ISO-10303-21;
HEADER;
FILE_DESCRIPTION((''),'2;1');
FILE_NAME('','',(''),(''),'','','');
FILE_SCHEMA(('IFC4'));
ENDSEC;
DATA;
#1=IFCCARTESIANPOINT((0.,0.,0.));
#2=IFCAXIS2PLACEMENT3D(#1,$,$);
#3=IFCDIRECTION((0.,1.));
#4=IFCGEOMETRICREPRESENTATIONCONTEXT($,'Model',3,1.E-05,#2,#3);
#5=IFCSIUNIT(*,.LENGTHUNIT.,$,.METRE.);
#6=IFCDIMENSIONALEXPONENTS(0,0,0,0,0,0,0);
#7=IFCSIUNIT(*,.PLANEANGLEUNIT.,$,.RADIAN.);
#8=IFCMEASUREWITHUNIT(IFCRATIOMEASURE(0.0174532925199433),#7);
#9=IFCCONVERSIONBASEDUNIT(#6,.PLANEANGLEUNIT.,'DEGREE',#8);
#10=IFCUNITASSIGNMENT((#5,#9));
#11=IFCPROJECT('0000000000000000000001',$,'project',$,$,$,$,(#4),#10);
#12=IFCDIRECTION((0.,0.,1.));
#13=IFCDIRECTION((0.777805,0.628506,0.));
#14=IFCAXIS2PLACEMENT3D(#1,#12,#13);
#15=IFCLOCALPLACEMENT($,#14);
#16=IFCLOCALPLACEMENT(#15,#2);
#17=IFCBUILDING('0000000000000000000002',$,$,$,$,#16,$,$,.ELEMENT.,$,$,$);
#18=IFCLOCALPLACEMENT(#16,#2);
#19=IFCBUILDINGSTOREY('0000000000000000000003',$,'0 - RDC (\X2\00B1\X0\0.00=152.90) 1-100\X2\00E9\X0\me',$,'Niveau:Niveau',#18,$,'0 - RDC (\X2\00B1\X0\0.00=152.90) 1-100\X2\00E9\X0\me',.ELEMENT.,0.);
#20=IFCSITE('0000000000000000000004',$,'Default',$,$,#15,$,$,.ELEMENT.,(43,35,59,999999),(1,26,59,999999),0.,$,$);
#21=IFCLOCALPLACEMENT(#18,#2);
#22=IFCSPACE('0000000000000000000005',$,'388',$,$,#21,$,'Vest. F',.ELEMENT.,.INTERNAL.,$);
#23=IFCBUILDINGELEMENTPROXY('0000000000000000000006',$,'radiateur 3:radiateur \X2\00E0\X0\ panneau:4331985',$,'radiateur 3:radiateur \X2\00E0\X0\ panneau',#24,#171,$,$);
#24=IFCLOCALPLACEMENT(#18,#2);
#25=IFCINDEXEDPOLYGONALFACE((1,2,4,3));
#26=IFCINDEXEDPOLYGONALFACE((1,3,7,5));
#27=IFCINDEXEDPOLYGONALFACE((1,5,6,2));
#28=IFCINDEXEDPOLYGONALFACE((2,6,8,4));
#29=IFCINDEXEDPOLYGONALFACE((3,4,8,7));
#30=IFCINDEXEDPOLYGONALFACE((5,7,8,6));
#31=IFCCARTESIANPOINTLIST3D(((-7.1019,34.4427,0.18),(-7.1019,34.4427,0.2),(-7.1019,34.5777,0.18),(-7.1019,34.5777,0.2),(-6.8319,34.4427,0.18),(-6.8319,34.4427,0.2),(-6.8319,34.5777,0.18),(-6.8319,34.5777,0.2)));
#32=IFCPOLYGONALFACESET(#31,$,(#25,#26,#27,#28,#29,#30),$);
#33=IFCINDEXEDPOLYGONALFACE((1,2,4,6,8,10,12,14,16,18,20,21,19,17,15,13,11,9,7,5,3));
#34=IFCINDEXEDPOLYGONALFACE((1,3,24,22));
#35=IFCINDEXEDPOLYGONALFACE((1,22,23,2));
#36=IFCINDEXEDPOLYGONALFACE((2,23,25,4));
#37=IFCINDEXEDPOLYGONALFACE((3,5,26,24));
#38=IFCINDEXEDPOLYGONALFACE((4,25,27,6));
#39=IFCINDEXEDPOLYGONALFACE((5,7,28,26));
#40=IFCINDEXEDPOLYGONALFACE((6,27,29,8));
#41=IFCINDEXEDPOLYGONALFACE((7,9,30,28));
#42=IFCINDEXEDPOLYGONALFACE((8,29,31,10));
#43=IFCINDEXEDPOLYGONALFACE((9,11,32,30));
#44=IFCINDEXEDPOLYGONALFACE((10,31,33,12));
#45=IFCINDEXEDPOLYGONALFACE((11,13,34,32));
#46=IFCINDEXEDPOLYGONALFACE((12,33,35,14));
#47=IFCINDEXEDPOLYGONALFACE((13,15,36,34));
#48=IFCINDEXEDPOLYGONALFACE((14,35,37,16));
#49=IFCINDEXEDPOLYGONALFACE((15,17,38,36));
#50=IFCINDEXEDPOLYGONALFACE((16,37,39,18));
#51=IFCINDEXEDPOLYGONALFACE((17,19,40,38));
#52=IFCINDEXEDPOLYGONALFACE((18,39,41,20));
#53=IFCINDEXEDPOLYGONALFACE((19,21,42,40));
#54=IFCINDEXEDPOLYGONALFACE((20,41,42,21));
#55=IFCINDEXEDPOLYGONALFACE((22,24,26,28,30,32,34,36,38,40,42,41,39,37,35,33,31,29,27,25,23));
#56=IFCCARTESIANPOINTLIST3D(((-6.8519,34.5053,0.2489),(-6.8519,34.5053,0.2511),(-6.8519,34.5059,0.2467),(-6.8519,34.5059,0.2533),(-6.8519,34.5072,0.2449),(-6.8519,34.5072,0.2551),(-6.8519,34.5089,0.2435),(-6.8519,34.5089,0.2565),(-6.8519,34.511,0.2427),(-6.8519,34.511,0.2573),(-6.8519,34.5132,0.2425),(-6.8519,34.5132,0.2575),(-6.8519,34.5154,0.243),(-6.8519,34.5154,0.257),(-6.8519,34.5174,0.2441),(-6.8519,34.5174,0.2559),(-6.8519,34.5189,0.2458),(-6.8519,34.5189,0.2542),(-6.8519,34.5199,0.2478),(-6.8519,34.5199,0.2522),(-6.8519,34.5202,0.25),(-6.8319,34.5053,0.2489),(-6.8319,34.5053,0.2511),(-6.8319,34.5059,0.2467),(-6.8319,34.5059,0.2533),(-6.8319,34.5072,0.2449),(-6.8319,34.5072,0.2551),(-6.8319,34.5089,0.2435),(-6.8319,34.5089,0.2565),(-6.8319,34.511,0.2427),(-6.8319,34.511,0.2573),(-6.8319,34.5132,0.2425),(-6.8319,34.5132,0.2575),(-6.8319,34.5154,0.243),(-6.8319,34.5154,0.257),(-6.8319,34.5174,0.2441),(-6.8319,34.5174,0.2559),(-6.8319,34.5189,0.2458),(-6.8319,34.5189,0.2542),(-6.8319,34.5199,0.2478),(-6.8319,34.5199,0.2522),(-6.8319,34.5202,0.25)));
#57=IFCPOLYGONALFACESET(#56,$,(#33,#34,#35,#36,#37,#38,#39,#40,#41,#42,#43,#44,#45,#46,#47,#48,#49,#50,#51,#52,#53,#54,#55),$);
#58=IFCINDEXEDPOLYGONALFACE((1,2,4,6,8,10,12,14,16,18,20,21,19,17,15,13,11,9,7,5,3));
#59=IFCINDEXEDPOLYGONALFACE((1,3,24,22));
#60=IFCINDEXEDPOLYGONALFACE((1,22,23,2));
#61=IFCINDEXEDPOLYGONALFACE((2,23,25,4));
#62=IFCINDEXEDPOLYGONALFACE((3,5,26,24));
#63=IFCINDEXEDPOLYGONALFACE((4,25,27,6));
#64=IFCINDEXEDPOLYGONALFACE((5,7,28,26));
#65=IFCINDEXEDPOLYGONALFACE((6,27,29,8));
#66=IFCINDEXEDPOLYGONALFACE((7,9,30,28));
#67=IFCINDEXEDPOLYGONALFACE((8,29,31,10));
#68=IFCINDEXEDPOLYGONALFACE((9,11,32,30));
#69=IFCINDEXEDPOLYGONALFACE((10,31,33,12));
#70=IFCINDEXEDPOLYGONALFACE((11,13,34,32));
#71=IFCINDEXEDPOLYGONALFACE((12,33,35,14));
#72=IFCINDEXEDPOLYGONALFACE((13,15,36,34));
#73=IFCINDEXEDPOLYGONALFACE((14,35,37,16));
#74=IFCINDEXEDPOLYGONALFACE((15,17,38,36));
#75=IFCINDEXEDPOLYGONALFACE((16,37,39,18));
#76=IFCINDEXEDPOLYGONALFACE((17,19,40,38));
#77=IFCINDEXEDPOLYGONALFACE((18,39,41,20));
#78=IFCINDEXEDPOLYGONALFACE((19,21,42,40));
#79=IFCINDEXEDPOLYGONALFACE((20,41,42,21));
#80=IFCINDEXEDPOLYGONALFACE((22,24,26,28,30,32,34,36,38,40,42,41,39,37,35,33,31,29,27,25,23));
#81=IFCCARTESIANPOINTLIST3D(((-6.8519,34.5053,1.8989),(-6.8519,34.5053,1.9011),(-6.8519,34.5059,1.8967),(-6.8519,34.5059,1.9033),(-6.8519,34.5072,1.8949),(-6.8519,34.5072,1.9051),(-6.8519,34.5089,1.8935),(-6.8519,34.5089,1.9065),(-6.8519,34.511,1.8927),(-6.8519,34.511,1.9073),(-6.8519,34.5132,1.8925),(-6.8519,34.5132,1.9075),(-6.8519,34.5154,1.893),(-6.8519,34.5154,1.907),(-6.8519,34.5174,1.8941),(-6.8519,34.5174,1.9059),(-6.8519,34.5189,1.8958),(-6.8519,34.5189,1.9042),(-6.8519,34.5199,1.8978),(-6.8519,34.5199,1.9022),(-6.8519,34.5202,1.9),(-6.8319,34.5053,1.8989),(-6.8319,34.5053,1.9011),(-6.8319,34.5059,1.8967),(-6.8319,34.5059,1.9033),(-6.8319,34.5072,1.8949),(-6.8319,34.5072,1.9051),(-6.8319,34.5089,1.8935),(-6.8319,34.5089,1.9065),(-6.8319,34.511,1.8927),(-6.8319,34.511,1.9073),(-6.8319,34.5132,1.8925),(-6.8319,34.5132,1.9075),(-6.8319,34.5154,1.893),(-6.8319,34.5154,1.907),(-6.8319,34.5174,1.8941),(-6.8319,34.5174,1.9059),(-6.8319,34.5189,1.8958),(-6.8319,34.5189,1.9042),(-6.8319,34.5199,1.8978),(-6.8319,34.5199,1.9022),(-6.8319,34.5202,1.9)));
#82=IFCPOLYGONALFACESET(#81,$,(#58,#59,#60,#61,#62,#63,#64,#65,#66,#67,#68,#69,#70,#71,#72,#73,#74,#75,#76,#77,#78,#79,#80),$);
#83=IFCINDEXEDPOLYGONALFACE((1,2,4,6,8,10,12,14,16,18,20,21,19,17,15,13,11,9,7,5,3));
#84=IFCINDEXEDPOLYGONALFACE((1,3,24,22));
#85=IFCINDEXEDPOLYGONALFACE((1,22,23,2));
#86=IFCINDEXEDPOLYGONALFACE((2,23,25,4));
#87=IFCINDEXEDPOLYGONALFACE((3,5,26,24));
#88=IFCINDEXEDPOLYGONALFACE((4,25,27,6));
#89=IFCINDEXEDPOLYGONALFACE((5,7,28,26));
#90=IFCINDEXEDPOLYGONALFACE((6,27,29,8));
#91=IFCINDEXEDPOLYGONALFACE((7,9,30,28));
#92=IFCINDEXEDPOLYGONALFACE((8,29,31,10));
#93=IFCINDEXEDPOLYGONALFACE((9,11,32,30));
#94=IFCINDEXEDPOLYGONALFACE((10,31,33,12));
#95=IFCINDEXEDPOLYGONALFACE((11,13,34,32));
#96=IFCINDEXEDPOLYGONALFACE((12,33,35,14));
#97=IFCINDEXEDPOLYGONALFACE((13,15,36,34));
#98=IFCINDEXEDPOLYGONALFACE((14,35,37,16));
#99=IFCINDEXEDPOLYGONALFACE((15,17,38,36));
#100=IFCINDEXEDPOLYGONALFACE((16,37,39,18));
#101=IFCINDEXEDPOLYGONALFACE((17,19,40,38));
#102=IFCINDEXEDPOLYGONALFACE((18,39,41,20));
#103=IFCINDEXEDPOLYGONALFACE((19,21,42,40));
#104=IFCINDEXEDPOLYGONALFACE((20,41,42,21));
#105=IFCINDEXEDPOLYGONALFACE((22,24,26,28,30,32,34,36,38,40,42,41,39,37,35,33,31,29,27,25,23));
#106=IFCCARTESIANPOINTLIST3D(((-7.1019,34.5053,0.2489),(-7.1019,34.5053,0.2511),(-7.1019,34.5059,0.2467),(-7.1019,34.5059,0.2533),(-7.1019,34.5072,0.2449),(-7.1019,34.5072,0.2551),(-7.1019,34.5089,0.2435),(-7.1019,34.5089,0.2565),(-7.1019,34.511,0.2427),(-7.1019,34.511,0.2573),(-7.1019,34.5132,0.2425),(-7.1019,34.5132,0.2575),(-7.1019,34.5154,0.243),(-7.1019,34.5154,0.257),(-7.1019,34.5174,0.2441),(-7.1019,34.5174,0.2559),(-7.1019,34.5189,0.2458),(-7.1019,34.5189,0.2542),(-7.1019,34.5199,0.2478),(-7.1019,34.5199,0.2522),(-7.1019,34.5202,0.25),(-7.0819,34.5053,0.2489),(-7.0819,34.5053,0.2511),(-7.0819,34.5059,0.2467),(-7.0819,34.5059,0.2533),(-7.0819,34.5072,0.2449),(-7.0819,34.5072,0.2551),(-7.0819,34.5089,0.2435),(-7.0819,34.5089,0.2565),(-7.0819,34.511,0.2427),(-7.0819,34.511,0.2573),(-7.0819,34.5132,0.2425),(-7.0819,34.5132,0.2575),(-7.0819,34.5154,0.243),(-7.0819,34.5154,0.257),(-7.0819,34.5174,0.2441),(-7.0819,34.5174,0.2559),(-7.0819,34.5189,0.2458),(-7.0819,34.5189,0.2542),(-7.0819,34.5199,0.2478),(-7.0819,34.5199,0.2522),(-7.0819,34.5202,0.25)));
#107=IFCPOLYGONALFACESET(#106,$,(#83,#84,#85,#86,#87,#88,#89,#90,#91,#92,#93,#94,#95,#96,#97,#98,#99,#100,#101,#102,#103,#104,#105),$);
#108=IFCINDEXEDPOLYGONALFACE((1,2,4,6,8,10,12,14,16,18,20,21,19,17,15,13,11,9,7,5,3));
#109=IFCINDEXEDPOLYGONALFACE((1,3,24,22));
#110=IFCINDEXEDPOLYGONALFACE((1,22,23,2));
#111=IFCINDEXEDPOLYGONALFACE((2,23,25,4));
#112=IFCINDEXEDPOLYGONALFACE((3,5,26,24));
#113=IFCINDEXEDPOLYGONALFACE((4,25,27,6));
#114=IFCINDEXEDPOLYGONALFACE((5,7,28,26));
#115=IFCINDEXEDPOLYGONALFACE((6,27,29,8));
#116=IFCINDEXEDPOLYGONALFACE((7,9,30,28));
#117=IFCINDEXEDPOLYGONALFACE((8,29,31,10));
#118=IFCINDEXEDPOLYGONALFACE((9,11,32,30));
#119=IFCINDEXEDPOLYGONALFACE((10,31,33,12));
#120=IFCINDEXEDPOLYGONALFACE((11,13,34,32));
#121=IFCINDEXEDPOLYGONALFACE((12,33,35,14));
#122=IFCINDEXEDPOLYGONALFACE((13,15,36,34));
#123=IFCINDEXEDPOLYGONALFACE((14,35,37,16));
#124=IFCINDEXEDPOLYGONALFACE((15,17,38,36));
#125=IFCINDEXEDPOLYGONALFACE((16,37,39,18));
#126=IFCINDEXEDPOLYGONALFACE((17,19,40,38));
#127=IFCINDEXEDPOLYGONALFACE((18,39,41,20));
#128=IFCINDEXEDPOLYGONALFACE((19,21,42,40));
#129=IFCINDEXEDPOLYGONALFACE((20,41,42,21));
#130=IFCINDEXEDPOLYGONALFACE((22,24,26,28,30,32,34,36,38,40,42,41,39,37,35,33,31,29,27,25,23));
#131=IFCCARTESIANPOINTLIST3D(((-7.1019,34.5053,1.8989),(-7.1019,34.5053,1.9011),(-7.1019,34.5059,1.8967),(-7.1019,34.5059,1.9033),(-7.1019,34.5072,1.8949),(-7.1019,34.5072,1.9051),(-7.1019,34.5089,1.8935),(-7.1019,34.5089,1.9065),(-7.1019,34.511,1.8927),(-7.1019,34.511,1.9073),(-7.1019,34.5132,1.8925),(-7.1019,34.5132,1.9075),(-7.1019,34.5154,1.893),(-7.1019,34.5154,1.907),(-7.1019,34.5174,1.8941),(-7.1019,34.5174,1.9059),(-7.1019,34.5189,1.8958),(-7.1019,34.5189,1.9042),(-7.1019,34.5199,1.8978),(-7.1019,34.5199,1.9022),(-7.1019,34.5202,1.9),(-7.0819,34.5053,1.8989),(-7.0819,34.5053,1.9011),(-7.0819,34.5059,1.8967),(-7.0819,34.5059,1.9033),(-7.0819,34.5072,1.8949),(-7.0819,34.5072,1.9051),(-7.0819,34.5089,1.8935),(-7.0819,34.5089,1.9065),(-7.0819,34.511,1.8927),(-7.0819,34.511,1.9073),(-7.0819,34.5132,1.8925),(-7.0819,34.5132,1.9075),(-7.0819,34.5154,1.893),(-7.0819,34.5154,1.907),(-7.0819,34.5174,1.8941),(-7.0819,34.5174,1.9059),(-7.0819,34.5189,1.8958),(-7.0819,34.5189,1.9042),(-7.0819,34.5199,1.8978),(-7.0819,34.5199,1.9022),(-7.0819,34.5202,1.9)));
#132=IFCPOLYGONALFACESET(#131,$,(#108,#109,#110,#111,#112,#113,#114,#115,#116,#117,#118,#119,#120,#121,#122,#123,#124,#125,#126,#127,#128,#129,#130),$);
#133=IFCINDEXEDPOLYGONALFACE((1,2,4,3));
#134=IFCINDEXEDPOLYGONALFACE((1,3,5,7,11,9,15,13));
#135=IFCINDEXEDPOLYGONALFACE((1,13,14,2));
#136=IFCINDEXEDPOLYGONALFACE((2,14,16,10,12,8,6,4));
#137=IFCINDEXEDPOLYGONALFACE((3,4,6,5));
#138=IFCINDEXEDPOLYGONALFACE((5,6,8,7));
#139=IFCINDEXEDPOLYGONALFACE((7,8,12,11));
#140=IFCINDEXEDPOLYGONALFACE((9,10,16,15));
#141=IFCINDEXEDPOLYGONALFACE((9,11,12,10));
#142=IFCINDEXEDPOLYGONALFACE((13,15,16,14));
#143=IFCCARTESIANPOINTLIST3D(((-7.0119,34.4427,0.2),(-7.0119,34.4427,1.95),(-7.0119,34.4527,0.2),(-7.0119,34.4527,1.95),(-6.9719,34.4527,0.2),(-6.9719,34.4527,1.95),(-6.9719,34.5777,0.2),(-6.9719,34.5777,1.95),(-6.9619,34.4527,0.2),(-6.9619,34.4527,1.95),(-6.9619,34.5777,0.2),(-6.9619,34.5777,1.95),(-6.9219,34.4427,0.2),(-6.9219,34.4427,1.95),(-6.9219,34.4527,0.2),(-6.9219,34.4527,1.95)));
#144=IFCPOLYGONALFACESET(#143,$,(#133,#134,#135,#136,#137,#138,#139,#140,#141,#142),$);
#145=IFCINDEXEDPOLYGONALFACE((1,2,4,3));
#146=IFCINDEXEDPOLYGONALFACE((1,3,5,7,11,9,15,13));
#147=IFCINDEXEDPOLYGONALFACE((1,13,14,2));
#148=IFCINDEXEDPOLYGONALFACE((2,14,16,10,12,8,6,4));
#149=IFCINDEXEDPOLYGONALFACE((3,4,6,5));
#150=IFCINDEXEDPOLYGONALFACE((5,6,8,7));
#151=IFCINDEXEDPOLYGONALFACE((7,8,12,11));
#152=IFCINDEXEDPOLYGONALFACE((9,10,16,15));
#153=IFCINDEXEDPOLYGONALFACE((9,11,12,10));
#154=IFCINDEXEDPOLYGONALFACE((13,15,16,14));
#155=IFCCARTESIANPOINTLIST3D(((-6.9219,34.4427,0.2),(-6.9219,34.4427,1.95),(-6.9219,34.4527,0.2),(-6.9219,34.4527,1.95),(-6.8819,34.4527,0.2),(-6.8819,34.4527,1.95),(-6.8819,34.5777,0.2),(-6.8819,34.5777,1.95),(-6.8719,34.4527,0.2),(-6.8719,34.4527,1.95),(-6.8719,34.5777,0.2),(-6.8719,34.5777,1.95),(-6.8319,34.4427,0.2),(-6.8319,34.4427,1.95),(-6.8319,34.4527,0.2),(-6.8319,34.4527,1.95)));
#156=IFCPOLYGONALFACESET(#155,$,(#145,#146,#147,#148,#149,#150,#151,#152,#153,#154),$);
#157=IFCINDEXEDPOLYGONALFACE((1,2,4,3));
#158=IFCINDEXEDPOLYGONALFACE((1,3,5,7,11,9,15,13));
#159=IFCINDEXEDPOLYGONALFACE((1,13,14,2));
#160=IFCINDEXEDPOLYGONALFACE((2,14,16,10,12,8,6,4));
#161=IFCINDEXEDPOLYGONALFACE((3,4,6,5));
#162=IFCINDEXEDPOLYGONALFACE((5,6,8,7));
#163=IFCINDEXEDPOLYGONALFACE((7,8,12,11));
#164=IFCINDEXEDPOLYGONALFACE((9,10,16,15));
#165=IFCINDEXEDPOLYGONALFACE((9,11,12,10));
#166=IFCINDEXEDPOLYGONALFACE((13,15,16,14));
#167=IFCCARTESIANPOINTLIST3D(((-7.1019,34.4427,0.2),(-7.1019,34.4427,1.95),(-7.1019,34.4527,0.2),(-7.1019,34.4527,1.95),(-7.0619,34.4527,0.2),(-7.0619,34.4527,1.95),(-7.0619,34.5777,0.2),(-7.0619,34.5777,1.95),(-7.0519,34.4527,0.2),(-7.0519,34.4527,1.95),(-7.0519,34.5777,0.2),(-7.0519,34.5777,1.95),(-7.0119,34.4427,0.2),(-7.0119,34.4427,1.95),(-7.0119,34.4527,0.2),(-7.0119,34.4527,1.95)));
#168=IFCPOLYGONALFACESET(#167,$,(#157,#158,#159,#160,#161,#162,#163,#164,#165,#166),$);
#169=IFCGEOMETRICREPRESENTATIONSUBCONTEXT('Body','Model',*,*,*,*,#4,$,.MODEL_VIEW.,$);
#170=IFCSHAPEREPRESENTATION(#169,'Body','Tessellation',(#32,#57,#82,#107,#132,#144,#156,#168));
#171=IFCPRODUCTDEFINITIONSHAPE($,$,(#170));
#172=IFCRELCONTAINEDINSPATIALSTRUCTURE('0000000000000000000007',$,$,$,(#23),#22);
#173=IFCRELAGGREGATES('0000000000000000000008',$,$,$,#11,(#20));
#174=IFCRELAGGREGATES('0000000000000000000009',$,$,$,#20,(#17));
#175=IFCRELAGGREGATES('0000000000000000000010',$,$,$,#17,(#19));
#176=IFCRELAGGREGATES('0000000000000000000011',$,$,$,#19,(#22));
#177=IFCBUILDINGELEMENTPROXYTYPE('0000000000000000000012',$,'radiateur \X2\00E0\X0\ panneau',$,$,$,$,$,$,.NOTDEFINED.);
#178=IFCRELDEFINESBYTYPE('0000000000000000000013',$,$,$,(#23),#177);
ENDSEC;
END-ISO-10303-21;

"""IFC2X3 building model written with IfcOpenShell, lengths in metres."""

from ifc_helpers import new_model, entity, si_unit, converted_unit, direction, frame, frame_2d, origin, origin_2d_with_axis, place, context, subcontext, project, spatial, polyline, rectangle, circle, outline, extrude, source, transform, mapped, type_object, type_shapes, element, save


model = new_model("IFC2X3")

# Units and contexts
model_context = context("Model", 3, precision=1e-05, world=origin(), true_north=direction((0.0, 1.0)))
body_context = subcontext(model_context, "Body", "Model", "MODEL_VIEW")
ifc_project = project(units=[si_unit("LENGTHUNIT", "METRE"), converted_unit("PLANEANGLEUNIT", "DEGREE", entity("IfcRatioMeasure", 0.0174532925199433), si_unit("PLANEANGLEUNIT", "RADIAN"), dimensions=[0, 0, 0, 0, 0, 0, 0])], contexts=[model_context])

# Site, building, storey
site_placement = place(None, frame((0.0, 0.0, 0.0), z_axis=(0.0, 0.0, 1.0), x_axis=(0.777805, 0.628506, 0.0)))
site = spatial("IfcSite", under=ifc_project, at=site_placement, Name="Default", CompositionType="ELEMENT", RefLatitude=(43, 35, 59, 999999), RefLongitude=(1, 26, 59, 999999), RefElevation=0.0)
building_placement = place(site_placement, origin())
building = spatial("IfcBuilding", under=site, at=building_placement, CompositionType="ELEMENT")
storey_placement = place(building_placement, origin())
storey = spatial("IfcBuildingStorey", under=building, at=storey_placement, Name="0 - RDC (±0.00=152.90) 1-100éme", ObjectType="Niveau:Niveau", LongName="0 - RDC (±0.00=152.90) 1-100éme", CompositionType="ELEMENT", Elevation=0.0)

# Shared definitions
building_element_proxy_type = type_object("IfcBuildingElementProxyType", Name="radiateur à panneau", PredefinedType="NOTDEFINED")
shared_shape_1 = source(origin(), body_context, "Body", "SweptSolid", [
    extrude(rectangle(XDim=0.135, YDim=0.27, at=frame_2d((0.0, 0.0), x_axis=(1.0, 0.0))), frame((0.135, -0.0025, -0.02), z_axis=(0.0, 0.0, 1.0), x_axis=(0.0, -1.0, 0.0)), (0.0, 0.0, 1.0), 0.02),
    extrude(circle(Radius=0.0075, at=frame_2d((0.0, 0.0), x_axis=(1.0, 0.0))), frame((0.25, 0.0, 0.05), z_axis=(1.0, 0.0, 0.0), x_axis=(0.0, 1.0, 0.0)), (0.0, 0.0, 1.0), 0.02),
    extrude(circle(Radius=0.0075, at=frame_2d((0.0, 0.0), x_axis=(1.0, 0.0))), frame((0.25, 0.0, 1.7), z_axis=(1.0, 0.0, 0.0), x_axis=(0.0, 1.0, 0.0)), (0.0, 0.0, 1.0), 0.02),
    extrude(circle(Radius=0.0075, at=frame_2d((0.0, 0.0), x_axis=(1.0, 0.0))), frame((0.0, 0.0, 0.05), z_axis=(1.0, 0.0, 0.0), x_axis=(0.0, 1.0, 0.0)), (0.0, 0.0, 1.0), 0.02),
    extrude(circle(Radius=0.0075, at=origin_2d_with_axis()), frame((0.0, 0.0, 1.7), z_axis=(1.0, 0.0, 0.0), x_axis=(0.0, 1.0, 0.0)), (0.0, 0.0, 1.0), 0.02),
    extrude(outline(polyline([(-0.005, -0.0963), (0.005, -0.0963), (0.005, 0.0288), (0.045, 0.0288), (0.045, 0.0387), (-0.045, 0.0387), (-0.045, 0.0288), (-0.005, 0.0288), (-0.005, -0.0963)])), frame((0.135, -0.0313, 0.0), z_axis=(0.0, 0.0, 1.0), x_axis=(-1.0, 0.0, 0.0)), (0.0, 0.0, 1.0), 1.75),
    extrude(outline(polyline([(-0.005, -0.0963), (0.005, -0.0963), (0.005, 0.0288), (0.045, 0.0288), (0.045, 0.0387), (-0.045, 0.0387), (-0.045, 0.0288), (-0.005, 0.0288), (-0.005, -0.0963)])), frame((0.225, -0.0313, 0.0), z_axis=(0.0, 0.0, 1.0), x_axis=(-1.0, 0.0, 0.0)), (0.0, 0.0, 1.0), 1.75),
    extrude(outline(polyline([(-0.005, -0.0963), (0.005, -0.0963), (0.005, 0.0288), (0.045, 0.0288), (0.045, 0.0387), (-0.045, 0.0387), (-0.045, 0.0288), (-0.005, 0.0288), (-0.005, -0.0963)])), frame((0.045, -0.0313, 0.0), z_axis=(0.0, 0.0, 1.0), x_axis=(-1.0, 0.0, 0.0)), (0.0, 0.0, 1.0), 1.75),
])
type_shapes(building_element_proxy_type, [shared_shape_1])

# Shared definitions
space_1_placement = place(storey_placement, origin())
space_1 = spatial("IfcSpace", under=storey, at=space_1_placement, Name="388", LongName="Vest. F", CompositionType="ELEMENT", InteriorOrExteriorSpace="INTERNAL")

# Building element proxy
proxy_1_placement = place(space_1_placement, frame((-7.1019, 34.5127, 0.2)))
element("IfcBuildingElementProxy", 1, at=proxy_1_placement, inside=space_1, type_object=building_element_proxy_type, Name="radiateur 3:radiateur à panneau:4331985", ObjectType="radiateur 3:radiateur à panneau", context=body_context, shape_type="MappedRepresentation", body=[
    mapped(shared_shape_1, transform((0.0, 0.0, 0.0), scale=1.0)),
])

save(model, "model.ifc")
